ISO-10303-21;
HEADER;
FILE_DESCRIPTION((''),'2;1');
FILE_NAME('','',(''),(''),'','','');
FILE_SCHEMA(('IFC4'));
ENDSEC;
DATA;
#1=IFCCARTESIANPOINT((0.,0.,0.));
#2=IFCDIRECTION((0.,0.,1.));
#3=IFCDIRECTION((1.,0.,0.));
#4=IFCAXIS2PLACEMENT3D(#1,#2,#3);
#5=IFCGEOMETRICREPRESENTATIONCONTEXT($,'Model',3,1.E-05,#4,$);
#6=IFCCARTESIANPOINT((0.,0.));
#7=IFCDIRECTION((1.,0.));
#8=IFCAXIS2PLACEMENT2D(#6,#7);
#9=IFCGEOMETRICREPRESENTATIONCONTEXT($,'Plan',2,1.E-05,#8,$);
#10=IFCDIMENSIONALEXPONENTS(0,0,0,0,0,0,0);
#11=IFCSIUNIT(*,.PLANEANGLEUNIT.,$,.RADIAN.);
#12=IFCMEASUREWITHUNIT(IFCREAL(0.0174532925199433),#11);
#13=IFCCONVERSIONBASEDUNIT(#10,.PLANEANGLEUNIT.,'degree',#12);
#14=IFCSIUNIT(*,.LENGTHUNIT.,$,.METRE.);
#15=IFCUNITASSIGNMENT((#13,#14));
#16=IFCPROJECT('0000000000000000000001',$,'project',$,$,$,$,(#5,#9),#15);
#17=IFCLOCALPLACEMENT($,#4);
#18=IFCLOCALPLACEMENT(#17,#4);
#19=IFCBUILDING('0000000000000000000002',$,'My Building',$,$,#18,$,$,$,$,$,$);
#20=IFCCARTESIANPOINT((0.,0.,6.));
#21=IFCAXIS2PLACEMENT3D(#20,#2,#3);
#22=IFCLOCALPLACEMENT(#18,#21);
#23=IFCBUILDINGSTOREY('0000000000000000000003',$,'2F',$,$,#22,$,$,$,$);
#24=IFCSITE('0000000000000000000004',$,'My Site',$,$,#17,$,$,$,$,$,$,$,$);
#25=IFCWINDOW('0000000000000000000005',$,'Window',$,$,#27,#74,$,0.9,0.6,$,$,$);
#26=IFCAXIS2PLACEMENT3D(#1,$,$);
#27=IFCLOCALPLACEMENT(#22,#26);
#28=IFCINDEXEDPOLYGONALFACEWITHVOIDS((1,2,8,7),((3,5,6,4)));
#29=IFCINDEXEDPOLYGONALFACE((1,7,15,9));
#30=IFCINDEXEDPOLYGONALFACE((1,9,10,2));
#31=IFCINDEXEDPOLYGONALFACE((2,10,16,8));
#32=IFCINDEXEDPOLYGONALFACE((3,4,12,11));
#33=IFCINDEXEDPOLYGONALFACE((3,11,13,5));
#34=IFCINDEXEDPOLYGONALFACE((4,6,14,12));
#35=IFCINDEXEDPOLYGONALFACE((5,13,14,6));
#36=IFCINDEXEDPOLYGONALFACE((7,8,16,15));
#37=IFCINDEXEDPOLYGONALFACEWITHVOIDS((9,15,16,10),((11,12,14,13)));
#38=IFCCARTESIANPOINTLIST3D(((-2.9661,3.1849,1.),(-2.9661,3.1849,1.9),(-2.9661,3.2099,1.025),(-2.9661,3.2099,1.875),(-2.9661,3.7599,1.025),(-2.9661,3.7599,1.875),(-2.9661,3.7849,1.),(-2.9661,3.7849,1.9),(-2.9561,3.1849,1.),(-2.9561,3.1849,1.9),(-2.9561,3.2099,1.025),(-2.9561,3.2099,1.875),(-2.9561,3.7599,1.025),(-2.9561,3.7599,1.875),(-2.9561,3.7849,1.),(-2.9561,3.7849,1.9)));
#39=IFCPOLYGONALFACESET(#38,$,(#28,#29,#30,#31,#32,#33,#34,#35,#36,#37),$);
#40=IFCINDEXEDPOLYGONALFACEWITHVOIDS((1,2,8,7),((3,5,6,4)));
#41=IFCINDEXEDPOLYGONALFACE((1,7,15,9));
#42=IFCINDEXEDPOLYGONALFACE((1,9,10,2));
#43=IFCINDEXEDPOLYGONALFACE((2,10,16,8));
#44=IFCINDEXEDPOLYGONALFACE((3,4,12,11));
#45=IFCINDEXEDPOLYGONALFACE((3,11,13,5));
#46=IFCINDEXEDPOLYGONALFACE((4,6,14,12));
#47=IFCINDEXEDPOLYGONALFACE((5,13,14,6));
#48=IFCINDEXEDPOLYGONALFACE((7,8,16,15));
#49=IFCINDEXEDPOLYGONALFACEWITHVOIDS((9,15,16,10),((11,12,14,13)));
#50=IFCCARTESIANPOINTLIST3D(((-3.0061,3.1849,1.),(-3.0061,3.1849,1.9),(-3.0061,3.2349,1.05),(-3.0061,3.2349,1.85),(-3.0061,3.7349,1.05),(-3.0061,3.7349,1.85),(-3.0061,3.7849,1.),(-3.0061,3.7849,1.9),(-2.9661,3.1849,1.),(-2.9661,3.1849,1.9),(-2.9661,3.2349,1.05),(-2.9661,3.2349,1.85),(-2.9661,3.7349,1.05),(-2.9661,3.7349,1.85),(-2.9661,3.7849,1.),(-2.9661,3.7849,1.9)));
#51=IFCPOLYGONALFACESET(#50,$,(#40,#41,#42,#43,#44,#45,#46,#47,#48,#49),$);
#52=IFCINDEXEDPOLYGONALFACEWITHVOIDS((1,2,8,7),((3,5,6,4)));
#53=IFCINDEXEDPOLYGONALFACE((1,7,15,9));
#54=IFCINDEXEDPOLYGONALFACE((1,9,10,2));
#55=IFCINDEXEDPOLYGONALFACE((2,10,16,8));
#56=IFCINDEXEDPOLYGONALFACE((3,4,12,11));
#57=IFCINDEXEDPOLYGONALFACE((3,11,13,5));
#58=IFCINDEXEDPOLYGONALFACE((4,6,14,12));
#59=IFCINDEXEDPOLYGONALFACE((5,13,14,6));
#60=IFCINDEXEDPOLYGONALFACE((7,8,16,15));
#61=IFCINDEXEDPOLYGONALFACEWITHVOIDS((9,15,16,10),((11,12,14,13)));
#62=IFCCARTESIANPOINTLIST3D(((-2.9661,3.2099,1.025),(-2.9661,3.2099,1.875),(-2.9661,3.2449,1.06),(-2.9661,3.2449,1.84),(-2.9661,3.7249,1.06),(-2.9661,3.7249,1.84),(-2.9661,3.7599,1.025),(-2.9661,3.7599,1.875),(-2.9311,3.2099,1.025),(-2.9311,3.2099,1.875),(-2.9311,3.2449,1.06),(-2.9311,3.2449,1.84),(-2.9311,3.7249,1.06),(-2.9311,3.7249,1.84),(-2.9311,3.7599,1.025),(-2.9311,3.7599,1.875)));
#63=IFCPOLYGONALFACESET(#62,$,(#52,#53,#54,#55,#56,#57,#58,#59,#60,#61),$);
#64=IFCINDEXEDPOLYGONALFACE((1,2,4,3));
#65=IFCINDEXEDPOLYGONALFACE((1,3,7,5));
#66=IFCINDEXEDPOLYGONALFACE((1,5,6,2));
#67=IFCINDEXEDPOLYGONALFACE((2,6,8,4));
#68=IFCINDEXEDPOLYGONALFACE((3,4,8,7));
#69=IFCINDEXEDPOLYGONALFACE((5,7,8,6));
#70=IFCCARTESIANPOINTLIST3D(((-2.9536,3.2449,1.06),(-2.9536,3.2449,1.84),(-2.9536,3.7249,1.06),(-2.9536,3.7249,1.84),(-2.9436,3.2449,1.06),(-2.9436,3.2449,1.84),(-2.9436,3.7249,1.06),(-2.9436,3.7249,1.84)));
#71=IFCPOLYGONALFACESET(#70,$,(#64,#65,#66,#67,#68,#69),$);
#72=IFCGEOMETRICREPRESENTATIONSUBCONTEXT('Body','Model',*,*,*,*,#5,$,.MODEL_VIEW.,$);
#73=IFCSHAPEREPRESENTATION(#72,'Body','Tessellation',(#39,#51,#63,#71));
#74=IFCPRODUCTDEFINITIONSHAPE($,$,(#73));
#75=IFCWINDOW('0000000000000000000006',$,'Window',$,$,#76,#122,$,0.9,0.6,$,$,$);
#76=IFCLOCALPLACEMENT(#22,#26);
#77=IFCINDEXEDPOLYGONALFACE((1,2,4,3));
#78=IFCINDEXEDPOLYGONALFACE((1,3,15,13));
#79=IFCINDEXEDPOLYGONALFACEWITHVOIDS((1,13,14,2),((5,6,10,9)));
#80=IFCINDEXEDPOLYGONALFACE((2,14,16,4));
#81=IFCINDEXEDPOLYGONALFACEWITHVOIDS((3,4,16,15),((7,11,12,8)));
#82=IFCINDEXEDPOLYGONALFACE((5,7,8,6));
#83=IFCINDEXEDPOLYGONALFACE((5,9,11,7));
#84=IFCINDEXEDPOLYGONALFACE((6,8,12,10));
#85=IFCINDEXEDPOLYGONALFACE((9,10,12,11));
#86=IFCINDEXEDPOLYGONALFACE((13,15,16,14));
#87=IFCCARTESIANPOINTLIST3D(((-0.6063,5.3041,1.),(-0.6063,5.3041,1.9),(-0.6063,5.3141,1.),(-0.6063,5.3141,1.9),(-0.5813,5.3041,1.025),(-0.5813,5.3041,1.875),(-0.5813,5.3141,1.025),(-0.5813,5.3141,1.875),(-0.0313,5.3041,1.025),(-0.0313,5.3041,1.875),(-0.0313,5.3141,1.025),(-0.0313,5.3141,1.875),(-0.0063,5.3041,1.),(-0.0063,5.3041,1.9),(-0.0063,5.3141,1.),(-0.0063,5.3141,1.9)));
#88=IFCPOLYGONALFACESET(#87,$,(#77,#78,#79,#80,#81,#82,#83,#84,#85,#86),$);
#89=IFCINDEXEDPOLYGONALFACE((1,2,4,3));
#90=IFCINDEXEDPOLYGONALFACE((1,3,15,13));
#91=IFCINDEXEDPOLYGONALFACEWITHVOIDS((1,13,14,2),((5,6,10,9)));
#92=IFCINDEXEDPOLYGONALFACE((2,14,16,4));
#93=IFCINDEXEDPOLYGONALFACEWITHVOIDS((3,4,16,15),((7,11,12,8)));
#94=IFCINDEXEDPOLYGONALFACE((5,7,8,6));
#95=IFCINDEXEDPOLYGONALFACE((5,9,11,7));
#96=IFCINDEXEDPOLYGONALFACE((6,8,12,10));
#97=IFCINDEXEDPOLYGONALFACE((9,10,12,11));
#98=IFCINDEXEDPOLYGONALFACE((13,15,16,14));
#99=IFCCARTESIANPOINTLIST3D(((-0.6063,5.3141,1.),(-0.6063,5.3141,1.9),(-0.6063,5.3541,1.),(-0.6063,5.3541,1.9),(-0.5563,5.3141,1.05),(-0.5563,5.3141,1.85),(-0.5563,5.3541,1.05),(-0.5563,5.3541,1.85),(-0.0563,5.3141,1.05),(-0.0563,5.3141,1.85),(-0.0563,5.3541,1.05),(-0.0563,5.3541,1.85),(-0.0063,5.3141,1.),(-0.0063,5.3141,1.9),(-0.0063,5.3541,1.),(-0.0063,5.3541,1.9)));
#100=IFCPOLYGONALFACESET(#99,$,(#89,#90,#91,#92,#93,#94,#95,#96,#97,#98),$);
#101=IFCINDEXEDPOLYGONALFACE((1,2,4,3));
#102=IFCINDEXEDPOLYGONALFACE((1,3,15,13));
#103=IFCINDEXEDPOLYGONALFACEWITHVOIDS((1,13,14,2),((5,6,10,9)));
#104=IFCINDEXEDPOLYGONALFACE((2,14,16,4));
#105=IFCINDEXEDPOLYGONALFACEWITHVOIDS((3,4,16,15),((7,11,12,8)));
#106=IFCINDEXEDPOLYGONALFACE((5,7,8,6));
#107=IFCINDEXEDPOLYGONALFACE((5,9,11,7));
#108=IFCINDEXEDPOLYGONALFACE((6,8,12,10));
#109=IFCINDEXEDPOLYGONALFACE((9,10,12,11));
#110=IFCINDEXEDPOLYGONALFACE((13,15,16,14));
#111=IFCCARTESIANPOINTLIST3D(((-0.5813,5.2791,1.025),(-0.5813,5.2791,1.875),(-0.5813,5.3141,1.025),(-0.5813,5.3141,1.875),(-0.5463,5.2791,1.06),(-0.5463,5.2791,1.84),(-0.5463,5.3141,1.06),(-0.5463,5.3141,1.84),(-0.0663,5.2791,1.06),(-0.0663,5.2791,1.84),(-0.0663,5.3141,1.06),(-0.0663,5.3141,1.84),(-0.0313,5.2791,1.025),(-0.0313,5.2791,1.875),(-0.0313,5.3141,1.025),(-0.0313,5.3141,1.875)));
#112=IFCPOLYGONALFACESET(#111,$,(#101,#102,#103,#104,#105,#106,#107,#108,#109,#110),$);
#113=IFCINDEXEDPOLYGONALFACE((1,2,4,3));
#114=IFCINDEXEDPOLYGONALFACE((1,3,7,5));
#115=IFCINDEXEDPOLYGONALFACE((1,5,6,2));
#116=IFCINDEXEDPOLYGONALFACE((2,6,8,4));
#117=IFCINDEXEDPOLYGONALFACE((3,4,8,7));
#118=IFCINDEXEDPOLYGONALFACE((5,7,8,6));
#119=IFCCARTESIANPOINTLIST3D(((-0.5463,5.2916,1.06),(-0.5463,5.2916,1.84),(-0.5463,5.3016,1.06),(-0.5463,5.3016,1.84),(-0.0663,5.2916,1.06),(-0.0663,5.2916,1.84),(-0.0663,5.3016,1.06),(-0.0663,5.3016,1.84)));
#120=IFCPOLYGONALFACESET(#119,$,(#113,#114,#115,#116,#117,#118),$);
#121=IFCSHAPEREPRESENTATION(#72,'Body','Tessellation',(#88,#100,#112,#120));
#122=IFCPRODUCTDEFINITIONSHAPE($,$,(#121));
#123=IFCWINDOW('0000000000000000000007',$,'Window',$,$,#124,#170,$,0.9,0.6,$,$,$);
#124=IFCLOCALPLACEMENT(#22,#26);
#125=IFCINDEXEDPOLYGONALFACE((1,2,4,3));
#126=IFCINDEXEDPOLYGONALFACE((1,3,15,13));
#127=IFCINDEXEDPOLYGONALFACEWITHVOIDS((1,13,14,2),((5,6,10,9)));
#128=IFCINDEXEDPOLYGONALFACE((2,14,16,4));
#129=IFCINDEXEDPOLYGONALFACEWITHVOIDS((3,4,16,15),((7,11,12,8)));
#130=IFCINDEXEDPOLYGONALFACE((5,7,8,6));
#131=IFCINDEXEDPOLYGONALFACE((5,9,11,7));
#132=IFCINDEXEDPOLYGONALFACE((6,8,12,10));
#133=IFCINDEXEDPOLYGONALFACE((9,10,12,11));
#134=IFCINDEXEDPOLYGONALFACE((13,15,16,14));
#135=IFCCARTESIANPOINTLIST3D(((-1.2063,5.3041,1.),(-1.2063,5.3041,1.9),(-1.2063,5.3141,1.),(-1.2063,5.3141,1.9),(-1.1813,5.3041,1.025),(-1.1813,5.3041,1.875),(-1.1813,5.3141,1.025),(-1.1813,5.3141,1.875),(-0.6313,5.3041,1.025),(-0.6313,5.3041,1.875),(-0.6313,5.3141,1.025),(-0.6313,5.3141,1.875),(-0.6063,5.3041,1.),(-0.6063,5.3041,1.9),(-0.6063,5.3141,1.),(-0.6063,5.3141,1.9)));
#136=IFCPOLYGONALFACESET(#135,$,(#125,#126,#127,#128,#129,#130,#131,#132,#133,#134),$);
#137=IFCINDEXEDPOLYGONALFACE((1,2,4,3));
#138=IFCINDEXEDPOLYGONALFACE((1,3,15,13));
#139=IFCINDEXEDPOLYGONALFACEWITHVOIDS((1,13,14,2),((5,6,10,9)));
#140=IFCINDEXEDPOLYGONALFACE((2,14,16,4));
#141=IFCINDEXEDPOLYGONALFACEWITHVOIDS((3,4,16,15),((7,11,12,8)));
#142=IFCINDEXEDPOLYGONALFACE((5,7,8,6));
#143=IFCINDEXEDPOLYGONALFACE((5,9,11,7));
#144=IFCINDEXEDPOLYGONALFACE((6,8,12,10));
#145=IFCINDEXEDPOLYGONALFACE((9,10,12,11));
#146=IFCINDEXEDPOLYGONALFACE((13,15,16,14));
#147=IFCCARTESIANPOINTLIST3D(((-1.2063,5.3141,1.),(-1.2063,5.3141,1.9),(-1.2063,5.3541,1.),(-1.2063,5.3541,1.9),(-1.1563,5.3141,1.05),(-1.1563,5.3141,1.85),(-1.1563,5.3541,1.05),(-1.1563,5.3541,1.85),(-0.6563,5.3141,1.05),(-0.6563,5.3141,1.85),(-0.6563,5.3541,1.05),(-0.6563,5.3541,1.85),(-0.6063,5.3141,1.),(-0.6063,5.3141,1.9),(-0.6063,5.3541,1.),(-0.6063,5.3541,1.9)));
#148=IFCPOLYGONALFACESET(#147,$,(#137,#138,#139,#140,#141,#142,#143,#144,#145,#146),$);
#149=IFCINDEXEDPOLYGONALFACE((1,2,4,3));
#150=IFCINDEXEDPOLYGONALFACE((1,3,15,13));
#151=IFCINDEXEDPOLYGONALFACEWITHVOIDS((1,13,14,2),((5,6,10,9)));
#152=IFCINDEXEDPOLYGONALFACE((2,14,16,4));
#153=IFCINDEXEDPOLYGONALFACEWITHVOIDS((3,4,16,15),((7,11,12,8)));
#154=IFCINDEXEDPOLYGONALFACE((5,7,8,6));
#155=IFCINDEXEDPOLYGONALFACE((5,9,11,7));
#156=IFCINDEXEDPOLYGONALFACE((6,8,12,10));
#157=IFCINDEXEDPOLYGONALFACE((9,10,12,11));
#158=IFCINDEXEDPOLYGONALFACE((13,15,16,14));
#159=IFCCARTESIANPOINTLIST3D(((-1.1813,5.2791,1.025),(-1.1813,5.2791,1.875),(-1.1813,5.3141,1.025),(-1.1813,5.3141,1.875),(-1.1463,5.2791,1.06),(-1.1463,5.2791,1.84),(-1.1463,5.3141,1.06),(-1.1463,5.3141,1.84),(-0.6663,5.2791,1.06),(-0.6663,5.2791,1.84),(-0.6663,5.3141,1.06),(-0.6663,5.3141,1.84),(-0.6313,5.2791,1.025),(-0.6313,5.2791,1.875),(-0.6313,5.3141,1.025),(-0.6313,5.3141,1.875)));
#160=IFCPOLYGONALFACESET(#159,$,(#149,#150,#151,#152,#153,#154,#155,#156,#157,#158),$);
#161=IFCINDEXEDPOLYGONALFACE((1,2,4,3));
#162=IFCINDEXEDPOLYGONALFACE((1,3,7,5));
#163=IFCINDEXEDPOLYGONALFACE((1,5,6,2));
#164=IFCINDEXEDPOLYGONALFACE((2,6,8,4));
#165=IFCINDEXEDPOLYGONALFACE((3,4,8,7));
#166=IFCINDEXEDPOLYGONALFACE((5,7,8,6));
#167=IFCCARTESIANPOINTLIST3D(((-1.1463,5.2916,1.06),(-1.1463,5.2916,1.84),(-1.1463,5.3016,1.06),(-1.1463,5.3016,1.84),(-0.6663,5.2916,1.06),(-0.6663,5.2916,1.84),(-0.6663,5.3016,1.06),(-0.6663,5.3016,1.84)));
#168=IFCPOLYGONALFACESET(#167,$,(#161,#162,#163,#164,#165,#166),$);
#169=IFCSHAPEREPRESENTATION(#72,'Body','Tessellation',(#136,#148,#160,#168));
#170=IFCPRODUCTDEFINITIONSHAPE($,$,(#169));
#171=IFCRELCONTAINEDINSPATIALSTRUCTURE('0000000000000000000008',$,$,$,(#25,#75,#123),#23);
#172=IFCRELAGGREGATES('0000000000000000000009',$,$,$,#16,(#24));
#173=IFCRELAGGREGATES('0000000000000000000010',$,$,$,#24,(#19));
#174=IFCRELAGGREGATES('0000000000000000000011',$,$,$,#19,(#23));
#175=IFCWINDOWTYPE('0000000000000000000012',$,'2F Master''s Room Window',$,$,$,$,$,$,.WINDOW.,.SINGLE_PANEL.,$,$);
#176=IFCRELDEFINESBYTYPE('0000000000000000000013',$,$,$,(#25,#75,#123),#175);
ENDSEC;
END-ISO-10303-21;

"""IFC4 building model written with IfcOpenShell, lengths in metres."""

from ifc_helpers import new_model, entity, si_unit, converted_unit, frame, origin_with_axes, origin_2d_with_axis, place, context, subcontext, project, spatial, line, indexed_curve, outline, extrude, shape, source, transform, mapped, type_object, type_shapes, element, save


model = new_model("IFC4")

# Units and contexts
model_context = context("Model", 3, precision=1e-05, world=origin_with_axes())
plan_context = context("Plan", 2, precision=1e-05, world=origin_2d_with_axis())
body_context_1 = subcontext(model_context, "Body", "Model", "MODEL_VIEW")
body_context_2 = subcontext(plan_context, "Body", "Plan", "PLAN_VIEW")
ifc_project = project(units=[converted_unit("PLANEANGLEUNIT", "degree", entity("IfcReal", 0.0174532925199433), si_unit("PLANEANGLEUNIT", "RADIAN"), dimensions=[0, 0, 0, 0, 0, 0, 0]), si_unit("LENGTHUNIT", "METRE")], contexts=[model_context, plan_context])

# Site, building, storey
site_placement = place(None, origin_with_axes())
site = spatial("IfcSite", under=ifc_project, at=site_placement, Name="My Site")
building_placement = place(site_placement, origin_with_axes())
building = spatial("IfcBuilding", under=site, at=building_placement, Name="My Building")
storey_placement = place(building_placement, frame((0.0, 0.0, 6.0), z_axis=(0.0, 0.0, 1.0), x_axis=(1.0, 0.0, 0.0)))
storey = spatial("IfcBuildingStorey", under=building, at=storey_placement, Name="2F")

# Shared definitions
window_type_1 = type_object("IfcWindowType", Name="2F Master's Room Window", PartitioningType="SINGLE_PANEL", PredefinedType="WINDOW")
shared_shape_1 = source(origin_with_axes(), body_context_1, "Body", "SweptSolid", [
    extrude(outline(indexed_curve([(0.0, 0.0), (0.6, 0.0), (0.6, 0.9), (0.0, 0.9)], segments=[line(1, 2, 3, 4, 1)]), holes=[indexed_curve([(0.025, 0.025), (0.575, 0.025), (0.575, 0.875), (0.025, 0.875)], segments=[line(1, 2, 3, 4, 1)])]), frame((0.0, 0.09, 0.0), z_axis=(0.0, -1.0, 0.0), x_axis=(1.0, 0.0, 0.0)), (0.0, 0.0, -1.0), 0.01),
    extrude(outline(indexed_curve([(0.0, 0.0), (0.6, 0.0), (0.6, 0.9), (0.0, 0.9)], segments=[line(1, 2, 3, 4, 1)]), holes=[indexed_curve([(0.05, 0.05), (0.55, 0.05), (0.55, 0.85), (0.05, 0.85)], segments=[line(1, 2, 3, 4, 1)])]), frame((0.0, 0.05, 0.0), z_axis=(0.0, -1.0, 0.0), x_axis=(1.0, 0.0, 0.0)), (0.0, 0.0, -1.0), 0.04),
    extrude(outline(indexed_curve([(0.0, 0.0), (0.55, 0.0), (0.55, 0.85), (0.0, 0.85)], segments=[line(1, 2, 3, 4, 1)]), holes=[indexed_curve([(0.035, 0.035), (0.515, 0.035), (0.515, 0.815), (0.035, 0.815)], segments=[line(1, 2, 3, 4, 1)])]), frame((0.025, 0.09, 0.025), z_axis=(0.0, -1.0, 0.0), x_axis=(1.0, 0.0, 0.0)), (0.0, 0.0, -1.0), 0.035),
    extrude(outline(indexed_curve([(0.035, 0.035), (0.515, 0.035), (0.515, 0.815), (0.035, 0.815)], segments=[line(1, 2, 3, 4, 1)])), frame((0.025, 0.1025, 0.025), z_axis=(0.0, -1.0, 0.0), x_axis=(1.0, 0.0, 0.0)), (0.0, 0.0, -1.0), 0.01),
])
shared_shape_2 = source(origin_with_axes(), body_context_2, "Body", "Curve2D", [
    entity("IfcIndexedPolyCurve", entity("IfcCartesianPointList2D", [[0.05, 0.05], [0.55, 0.05]])),
    entity("IfcIndexedPolyCurve", entity("IfcCartesianPointList2D", [[0.0, 0.1], [0.025, 0.1], [0.025, 0.09], [0.05, 0.09], [0.05, 0.05], [0.0, 0.05]]), [entity("IfcLineIndex", [1, 2, 3, 4, 5, 6, 1])]),
    entity("IfcIndexedPolyCurve", entity("IfcCartesianPointList2D", [[0.6, 0.1], [0.575, 0.1], [0.575, 0.09], [0.55, 0.09], [0.55, 0.05], [0.6, 0.05]]), [entity("IfcLineIndex", [1, 2, 3, 4, 5, 6, 1])]),
    entity("IfcIndexedPolyCurve", entity("IfcCartesianPointList2D", [[0.025, 0.09], [0.06, 0.09], [0.06, 0.125], [0.025, 0.125]]), [entity("IfcLineIndex", [1, 2, 3, 4, 1])]),
    entity("IfcIndexedPolyCurve", entity("IfcCartesianPointList2D", [[0.575, 0.09], [0.54, 0.09], [0.54, 0.125], [0.575, 0.125]]), [entity("IfcLineIndex", [1, 2, 3, 4, 1])]),
    entity("IfcIndexedPolyCurve", entity("IfcCartesianPointList2D", [[0.06, 0.09], [0.54, 0.09]])),
    entity("IfcIndexedPolyCurve", entity("IfcCartesianPointList2D", [[0.06, 0.125], [0.54, 0.125]])),
    entity("IfcIndexedPolyCurve", entity("IfcCartesianPointList2D", [[0.06, 0.1075], [0.54, 0.1075]])),
])
type_shapes(window_type_1, [shared_shape_1, shared_shape_2])

# Windows
placement_1 = place(storey_placement, frame((-3.0561, 5.4041, 0.0), z_axis=(0.0, 0.0, 1.0), x_axis=(0.0, -1.0, 0.0)))
placement_2 = place(placement_1, frame((1.6192, 0.0, 1.0), z_axis=(0.0, 0.0, 1.0), x_axis=(1.0, 0.0, 0.0)))
window_1_placement = place(placement_2, frame((0.0, 0.0, 0.0), z_axis=(0.0, 0.0, 1.0), x_axis=(1.0, 0.0, 0.0)))
element("IfcWindow", 1, at=window_1_placement, inside=storey, type_object=window_type_1, Name="Window", OverallHeight=0.9, OverallWidth=0.6, shapes=[
    shape(body_context_1, "Body", "MappedRepresentation", [mapped(shared_shape_1, transform((0.0, 0.0, 0.0), x_axis=(1.0, 0.0, 0.0), y_axis=(0.0, 1.0, 0.0), z_axis=(0.0, 0.0, 1.0), scale=1.0))]),
    shape(body_context_2, "Body", "MappedRepresentation", [mapped(shared_shape_2, transform((0.0, 0.0, 0.0), x_axis=(1.0, 0.0, 0.0), y_axis=(0.0, 1.0, 0.0), z_axis=(0.0, 0.0, 1.0), scale=1.0))]),
])
placement_3 = place(storey_placement, frame((0.4439, 5.4041, 0.0), z_axis=(0.0, 0.0, 1.0), x_axis=(-1.0, 0.0, 0.0)))
placement_4 = place(placement_3, frame((0.4503, 0.0, 1.0), z_axis=(0.0, 0.0, 1.0), x_axis=(1.0, 0.0, 0.0)))
window_2_placement = place(placement_4, frame((0.0, 0.0, 0.0), z_axis=(0.0, 0.0, 1.0), x_axis=(1.0, 0.0, 0.0)))
element("IfcWindow", 2, at=window_2_placement, inside=storey, type_object=window_type_1, Name="Window", OverallHeight=0.9, OverallWidth=0.6, shapes=[
    shape(body_context_1, "Body", "MappedRepresentation", [mapped(shared_shape_1, transform((0.0, 0.0, 0.0), x_axis=(1.0, 0.0, 0.0), y_axis=(0.0, 1.0, 0.0), z_axis=(0.0, 0.0, 1.0), scale=1.0))]),
    shape(body_context_2, "Body", "MappedRepresentation", [mapped(shared_shape_2, transform((0.0, 0.0, 0.0), x_axis=(1.0, 0.0, 0.0), y_axis=(0.0, 1.0, 0.0), z_axis=(0.0, 0.0, 1.0), scale=1.0))]),
])
placement_5 = place(placement_3, frame((1.0503, 0.0, 1.0), z_axis=(0.0, 0.0, 1.0), x_axis=(1.0, 0.0, 0.0)))
window_3_placement = place(placement_5, frame((0.0, 0.0, 0.0), z_axis=(0.0, 0.0, 1.0), x_axis=(1.0, 0.0, 0.0)))
element("IfcWindow", 3, at=window_3_placement, inside=storey, type_object=window_type_1, Name="Window", OverallHeight=0.9, OverallWidth=0.6, shapes=[
    shape(body_context_1, "Body", "MappedRepresentation", [mapped(shared_shape_1, transform((0.0, 0.0, 0.0), x_axis=(1.0, 0.0, 0.0), y_axis=(0.0, 1.0, 0.0), z_axis=(0.0, 0.0, 1.0), scale=1.0))]),
    shape(body_context_2, "Body", "MappedRepresentation", [mapped(shared_shape_2, transform((0.0, 0.0, 0.0), x_axis=(1.0, 0.0, 0.0), y_axis=(0.0, 1.0, 0.0), z_axis=(0.0, 0.0, 1.0), scale=1.0))]),
])

save(model, "model.ifc")
